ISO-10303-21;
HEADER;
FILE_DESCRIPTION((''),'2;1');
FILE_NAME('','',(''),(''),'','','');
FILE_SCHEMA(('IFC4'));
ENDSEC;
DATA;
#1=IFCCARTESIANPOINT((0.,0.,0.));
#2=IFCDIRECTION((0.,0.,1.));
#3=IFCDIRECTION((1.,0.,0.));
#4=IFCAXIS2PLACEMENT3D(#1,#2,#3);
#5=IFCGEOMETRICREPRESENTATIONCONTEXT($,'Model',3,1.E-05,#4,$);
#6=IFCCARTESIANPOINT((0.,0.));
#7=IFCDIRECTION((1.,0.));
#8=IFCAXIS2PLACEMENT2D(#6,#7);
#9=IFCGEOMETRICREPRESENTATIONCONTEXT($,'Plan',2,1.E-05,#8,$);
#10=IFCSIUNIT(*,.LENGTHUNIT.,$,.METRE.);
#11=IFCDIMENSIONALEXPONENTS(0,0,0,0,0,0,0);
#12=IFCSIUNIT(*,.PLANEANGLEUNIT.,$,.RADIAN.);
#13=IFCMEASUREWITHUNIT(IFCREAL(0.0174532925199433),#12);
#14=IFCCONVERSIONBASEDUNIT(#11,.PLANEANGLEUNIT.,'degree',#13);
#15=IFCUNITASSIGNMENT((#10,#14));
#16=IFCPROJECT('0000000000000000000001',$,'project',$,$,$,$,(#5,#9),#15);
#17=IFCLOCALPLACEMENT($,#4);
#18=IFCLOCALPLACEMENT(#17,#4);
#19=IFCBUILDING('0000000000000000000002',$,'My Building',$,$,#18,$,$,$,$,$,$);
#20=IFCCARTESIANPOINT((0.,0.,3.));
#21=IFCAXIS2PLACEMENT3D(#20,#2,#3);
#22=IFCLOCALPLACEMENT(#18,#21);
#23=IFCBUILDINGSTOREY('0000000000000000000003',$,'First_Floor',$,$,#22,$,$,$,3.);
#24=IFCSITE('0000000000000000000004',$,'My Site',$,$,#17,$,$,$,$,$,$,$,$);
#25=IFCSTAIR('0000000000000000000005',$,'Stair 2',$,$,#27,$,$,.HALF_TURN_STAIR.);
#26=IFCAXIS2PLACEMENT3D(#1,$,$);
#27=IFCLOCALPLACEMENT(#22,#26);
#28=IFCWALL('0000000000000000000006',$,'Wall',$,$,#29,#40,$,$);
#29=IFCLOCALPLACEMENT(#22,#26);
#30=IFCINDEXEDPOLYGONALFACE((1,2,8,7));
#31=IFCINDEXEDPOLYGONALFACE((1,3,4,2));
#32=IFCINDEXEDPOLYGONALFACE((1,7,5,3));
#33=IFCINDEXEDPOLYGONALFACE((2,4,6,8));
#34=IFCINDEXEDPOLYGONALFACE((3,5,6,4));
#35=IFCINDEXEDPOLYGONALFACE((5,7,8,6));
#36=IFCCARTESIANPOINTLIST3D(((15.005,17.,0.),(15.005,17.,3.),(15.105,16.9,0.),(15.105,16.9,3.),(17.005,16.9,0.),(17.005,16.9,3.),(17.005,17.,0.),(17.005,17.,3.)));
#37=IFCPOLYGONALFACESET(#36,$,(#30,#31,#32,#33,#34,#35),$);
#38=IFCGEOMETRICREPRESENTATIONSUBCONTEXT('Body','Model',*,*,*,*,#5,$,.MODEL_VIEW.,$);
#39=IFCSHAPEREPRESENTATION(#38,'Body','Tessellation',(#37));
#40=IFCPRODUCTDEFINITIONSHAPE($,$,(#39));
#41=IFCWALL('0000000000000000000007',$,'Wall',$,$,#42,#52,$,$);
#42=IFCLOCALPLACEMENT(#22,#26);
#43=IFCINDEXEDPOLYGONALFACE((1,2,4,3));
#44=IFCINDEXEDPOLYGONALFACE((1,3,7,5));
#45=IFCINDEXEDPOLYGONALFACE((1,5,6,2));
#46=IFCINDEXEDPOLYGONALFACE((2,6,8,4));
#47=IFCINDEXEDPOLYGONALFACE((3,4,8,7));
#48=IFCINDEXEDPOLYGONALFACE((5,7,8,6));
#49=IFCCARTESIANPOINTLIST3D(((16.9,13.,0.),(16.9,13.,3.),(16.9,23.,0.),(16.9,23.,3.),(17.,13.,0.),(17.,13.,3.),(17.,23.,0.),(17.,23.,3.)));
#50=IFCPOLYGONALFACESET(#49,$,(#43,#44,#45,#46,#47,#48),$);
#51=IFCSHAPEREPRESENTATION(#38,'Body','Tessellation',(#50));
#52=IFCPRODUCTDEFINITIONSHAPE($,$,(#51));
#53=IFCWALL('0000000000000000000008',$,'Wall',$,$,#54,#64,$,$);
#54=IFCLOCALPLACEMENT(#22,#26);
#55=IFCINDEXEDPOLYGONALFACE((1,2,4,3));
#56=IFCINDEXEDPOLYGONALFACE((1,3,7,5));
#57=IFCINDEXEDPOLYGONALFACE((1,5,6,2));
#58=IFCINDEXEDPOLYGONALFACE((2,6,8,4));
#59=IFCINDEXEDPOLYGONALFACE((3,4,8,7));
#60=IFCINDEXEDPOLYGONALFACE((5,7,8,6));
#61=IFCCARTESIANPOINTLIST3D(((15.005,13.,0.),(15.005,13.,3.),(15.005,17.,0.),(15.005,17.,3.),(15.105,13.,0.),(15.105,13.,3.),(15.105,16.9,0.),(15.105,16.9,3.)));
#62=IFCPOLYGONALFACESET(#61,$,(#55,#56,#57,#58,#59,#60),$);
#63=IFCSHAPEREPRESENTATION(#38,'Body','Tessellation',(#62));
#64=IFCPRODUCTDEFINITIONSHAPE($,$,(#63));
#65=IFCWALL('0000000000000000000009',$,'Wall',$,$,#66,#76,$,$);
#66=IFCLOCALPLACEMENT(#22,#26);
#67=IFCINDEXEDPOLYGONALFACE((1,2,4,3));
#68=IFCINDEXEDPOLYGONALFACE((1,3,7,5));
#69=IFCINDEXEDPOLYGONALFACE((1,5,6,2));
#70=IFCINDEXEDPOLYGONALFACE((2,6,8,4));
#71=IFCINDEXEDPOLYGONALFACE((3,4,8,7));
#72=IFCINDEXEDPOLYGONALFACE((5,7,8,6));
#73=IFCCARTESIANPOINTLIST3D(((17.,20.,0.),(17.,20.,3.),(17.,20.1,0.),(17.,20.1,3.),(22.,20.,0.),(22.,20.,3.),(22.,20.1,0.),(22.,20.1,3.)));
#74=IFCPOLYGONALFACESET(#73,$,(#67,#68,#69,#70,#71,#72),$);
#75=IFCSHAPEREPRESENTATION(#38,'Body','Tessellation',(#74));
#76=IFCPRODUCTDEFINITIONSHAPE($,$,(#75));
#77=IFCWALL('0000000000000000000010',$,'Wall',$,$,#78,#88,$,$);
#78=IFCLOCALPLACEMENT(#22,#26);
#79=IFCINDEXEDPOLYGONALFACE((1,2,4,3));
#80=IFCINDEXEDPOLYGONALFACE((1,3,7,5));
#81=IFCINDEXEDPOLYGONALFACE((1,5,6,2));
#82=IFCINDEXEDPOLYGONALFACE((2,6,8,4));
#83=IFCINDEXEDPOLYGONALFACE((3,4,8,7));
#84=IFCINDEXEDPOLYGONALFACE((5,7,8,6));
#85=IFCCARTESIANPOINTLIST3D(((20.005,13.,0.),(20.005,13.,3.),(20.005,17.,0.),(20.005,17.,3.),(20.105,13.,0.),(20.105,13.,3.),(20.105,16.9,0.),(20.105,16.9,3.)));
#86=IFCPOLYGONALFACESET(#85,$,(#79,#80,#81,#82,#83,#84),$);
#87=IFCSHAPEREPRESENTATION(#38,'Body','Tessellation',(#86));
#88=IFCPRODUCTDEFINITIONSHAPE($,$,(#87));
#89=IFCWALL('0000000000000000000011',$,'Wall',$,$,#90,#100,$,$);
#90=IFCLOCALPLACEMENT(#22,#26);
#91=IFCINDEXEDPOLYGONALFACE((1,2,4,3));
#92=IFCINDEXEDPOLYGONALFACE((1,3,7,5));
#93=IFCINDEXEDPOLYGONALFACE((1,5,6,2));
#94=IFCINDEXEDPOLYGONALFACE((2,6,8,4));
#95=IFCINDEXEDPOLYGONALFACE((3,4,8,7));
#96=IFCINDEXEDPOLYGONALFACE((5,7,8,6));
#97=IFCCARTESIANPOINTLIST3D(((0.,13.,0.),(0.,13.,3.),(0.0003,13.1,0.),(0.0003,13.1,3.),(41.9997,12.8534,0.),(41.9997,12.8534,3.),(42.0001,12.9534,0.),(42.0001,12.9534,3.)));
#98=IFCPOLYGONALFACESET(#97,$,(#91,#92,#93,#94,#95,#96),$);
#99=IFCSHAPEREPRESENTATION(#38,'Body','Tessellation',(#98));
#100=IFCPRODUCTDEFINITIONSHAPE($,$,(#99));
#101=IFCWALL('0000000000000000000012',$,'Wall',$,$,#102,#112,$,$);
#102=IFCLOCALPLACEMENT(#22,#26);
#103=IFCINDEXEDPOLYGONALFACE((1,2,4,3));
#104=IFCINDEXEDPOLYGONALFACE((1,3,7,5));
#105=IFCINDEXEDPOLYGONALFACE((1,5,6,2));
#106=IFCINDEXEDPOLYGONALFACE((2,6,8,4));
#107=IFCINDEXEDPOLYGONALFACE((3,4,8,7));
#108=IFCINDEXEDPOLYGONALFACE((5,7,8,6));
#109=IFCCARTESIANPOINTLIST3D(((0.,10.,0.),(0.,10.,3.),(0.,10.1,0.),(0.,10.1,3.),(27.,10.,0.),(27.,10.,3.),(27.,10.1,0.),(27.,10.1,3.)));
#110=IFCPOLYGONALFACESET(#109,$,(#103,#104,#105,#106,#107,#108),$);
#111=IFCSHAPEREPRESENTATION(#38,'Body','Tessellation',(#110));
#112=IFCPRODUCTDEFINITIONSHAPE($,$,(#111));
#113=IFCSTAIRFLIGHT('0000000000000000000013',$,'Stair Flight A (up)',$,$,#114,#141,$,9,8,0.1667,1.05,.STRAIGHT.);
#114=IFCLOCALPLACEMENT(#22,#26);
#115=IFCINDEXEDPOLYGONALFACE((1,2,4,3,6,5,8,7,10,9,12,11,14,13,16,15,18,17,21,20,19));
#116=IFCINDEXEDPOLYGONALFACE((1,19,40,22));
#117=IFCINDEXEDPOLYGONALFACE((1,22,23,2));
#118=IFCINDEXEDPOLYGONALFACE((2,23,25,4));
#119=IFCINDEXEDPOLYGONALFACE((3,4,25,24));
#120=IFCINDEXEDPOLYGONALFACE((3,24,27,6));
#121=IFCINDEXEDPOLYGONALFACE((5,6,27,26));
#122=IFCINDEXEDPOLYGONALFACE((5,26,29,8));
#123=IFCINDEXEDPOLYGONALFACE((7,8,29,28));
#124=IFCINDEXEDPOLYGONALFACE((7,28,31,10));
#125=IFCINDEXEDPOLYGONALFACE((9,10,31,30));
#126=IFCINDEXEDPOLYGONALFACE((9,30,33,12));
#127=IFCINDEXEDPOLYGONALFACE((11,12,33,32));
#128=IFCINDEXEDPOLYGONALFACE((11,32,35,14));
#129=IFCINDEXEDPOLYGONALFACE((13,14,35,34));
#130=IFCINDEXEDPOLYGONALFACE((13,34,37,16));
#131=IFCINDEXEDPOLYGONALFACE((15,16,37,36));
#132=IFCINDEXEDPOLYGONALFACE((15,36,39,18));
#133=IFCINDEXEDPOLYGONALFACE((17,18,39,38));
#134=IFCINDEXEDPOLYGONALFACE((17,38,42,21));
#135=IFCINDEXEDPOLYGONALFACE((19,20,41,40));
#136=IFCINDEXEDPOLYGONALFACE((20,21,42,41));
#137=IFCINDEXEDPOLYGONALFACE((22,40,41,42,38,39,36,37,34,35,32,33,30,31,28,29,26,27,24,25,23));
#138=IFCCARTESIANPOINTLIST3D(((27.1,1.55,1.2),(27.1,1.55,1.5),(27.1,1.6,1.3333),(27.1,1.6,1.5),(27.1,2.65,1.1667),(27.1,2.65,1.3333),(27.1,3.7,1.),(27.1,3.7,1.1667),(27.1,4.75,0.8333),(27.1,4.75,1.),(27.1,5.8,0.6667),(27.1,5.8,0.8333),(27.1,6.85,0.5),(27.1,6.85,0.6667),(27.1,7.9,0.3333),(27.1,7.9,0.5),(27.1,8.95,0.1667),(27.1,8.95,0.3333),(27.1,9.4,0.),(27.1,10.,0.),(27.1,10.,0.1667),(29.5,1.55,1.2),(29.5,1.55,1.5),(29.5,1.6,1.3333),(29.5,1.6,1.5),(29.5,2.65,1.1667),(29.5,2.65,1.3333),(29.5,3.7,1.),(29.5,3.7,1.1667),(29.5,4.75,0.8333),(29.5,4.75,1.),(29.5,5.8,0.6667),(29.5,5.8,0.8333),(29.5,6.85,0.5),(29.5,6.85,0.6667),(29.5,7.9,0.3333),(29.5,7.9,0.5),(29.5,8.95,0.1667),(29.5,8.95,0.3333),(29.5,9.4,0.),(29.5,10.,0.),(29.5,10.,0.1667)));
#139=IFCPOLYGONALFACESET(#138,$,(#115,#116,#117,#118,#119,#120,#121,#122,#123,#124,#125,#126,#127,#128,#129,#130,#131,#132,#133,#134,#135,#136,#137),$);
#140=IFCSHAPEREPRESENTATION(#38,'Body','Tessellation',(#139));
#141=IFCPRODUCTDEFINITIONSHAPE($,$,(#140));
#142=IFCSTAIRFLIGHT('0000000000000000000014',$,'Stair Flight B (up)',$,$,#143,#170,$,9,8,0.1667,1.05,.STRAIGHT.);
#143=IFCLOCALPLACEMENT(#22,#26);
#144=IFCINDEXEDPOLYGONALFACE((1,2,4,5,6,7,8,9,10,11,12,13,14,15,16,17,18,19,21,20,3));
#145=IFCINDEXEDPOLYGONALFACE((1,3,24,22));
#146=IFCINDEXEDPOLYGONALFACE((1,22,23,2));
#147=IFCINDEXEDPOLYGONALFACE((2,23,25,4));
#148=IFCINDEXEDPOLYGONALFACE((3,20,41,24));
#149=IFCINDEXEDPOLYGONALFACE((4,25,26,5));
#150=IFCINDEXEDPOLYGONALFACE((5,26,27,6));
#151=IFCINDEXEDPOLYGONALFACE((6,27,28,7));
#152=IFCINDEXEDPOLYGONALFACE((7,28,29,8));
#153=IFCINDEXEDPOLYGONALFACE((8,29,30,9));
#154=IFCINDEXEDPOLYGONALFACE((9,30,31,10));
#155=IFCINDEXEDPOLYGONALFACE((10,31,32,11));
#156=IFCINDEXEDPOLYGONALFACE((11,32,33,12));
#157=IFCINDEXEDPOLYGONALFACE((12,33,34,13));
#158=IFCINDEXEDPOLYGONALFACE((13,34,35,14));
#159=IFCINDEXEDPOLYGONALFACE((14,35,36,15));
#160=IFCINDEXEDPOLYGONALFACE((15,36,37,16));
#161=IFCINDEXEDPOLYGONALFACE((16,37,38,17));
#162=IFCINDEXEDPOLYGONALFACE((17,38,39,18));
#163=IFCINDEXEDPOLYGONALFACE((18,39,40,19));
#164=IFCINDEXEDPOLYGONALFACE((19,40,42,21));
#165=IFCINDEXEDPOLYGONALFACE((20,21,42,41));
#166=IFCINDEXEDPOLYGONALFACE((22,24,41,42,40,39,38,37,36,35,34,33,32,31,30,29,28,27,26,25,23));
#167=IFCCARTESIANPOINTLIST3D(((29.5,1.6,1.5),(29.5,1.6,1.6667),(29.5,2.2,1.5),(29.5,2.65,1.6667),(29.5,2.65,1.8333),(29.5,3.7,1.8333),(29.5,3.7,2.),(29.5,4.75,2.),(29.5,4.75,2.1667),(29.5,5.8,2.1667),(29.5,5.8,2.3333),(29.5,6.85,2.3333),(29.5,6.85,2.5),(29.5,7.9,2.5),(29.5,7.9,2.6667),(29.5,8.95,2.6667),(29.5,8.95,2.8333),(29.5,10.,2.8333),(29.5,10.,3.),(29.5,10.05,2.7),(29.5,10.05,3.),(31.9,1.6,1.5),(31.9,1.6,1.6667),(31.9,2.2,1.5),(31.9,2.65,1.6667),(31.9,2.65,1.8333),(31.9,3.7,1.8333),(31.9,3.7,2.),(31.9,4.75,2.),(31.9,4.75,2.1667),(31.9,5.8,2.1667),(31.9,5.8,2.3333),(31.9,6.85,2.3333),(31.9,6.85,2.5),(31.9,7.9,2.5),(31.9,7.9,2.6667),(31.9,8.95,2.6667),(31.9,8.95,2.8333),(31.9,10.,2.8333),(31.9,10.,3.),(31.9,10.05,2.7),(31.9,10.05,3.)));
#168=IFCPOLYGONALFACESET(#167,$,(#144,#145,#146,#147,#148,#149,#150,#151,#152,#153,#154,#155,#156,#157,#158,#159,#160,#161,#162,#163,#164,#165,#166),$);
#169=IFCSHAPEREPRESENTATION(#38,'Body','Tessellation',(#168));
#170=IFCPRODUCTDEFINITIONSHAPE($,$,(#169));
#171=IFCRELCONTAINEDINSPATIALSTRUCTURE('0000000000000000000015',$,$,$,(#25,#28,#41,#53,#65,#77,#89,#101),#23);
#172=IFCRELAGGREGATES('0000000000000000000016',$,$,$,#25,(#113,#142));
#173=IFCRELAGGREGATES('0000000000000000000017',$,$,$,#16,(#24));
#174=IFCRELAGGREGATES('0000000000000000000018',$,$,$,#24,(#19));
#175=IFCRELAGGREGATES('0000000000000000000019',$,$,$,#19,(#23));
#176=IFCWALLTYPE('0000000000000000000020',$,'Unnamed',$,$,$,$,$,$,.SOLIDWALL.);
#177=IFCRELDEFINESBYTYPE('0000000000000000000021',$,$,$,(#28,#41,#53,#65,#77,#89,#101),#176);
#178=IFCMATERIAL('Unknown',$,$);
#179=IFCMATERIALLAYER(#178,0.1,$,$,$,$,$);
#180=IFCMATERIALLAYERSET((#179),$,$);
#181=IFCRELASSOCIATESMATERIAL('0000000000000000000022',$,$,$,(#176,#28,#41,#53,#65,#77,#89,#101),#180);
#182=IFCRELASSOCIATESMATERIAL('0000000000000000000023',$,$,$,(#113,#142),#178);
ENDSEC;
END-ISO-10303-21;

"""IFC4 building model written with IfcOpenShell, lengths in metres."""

from ifc_helpers import new_model, entity, si_unit, converted_unit, frame, origin_with_axes, origin_2d_with_axis, place, context, subcontext, project, spatial, polyline, line, indexed_curve, outline, extrude, material, layer, layer_set, layer_usage, type_object, element, aggregate, save


model = new_model("IFC4")

# Units and contexts
model_context = context("Model", 3, precision=1e-05, world=origin_with_axes())
plan_context = context("Plan", 2, precision=1e-05, world=origin_2d_with_axis())
body_context = subcontext(model_context, "Body", "Model", "MODEL_VIEW")
ifc_project = project(units=[si_unit("LENGTHUNIT", "METRE"), converted_unit("PLANEANGLEUNIT", "degree", entity("IfcReal", 0.0174532925199433), si_unit("PLANEANGLEUNIT", "RADIAN"), dimensions=[0, 0, 0, 0, 0, 0, 0])], contexts=[model_context, plan_context])

# Site, building, storey
site_placement = place(None, origin_with_axes())
site = spatial("IfcSite", under=ifc_project, at=site_placement, Name="My Site")
building_placement = place(site_placement, origin_with_axes())
building = spatial("IfcBuilding", under=site, at=building_placement, Name="My Building")
storey_placement = place(building_placement, frame((0.0, 0.0, 3.0), z_axis=(0.0, 0.0, 1.0), x_axis=(1.0, 0.0, 0.0)))
storey = spatial("IfcBuildingStorey", under=building, at=storey_placement, Name="First_Floor", Elevation=3.0)

# Stair
stair_placement = place(storey_placement, origin_with_axes())
stair = element("IfcStair", 1, at=stair_placement, inside=storey, Name="Stair 2", PredefinedType="HALF_TURN_STAIR")
ifc_material = material(Name="Unknown")

# Walls
ifc_layer = layer(ifc_material, 0.1)
ifc_layer_set = layer_set([ifc_layer])
wall_type = type_object("IfcWallType", Name="Unnamed", PredefinedType="SOLIDWALL", material=ifc_layer_set)
ifc_layer_usage_1 = layer_usage(ifc_layer_set, "AXIS2", "POSITIVE", 0.0)
wall_1_placement = place(storey_placement, frame((17.005, 17.0, 0.0), z_axis=(0.0, 0.0, 1.0), x_axis=(-1.0, 0.0, 0.0)))
element("IfcWall", 2, at=wall_1_placement, inside=storey, type_object=wall_type, material=ifc_layer_usage_1, Name="Wall", context=body_context, shape_type="SweptSolid", body=[
    extrude(outline(indexed_curve([(0.0, 0.0), (0.0, 0.1), (1.9, 0.1), (2.0, 0.0)], segments=[line(1, 2, 3, 4, 1)])), origin_with_axes(), (0.0, 0.0, 1.0), 3.0),
])
ifc_layer_usage_2 = layer_usage(ifc_layer_set, "AXIS2", "POSITIVE", 0.0)
wall_2_placement = place(storey_placement, frame((16.9, 23.0, 0.0), z_axis=(0.0, 0.0, 1.0), x_axis=(0.0, -1.0, 0.0)))
element("IfcWall", 3, at=wall_2_placement, inside=storey, type_object=wall_type, material=ifc_layer_usage_2, Name="Wall", context=body_context, shape_type="SweptSolid", body=[
    extrude(outline(indexed_curve([(0.0, 0.0), (0.0, 0.1), (10.0, 0.1), (10.0, 0.0)], segments=[line(1, 2, 3, 4, 1)])), origin_with_axes(), (0.0, 0.0, 1.0), 3.0),
])
ifc_layer_usage_3 = layer_usage(ifc_layer_set, "AXIS2", "POSITIVE", 0.0)
wall_3_placement = place(storey_placement, frame((15.005, 17.0, 0.0), z_axis=(0.0, 0.0, 1.0), x_axis=(0.0, -1.0, 0.0)))
element("IfcWall", 4, at=wall_3_placement, inside=storey, type_object=wall_type, material=ifc_layer_usage_3, Name="Wall", context=body_context, shape_type="SweptSolid", body=[
    extrude(outline(indexed_curve([(0.0, 0.0), (0.1, 0.1), (4.0, 0.1), (4.0, 0.0)], segments=[line(1, 2, 3, 4, 1)])), origin_with_axes(), (0.0, 0.0, 1.0), 3.0),
])
ifc_layer_usage_4 = layer_usage(ifc_layer_set, "AXIS2", "POSITIVE", 0.0)
wall_4_placement = place(storey_placement, frame((17.0, 20.0, 0.0), z_axis=(0.0, 0.0, 1.0), x_axis=(1.0, 0.0, 0.0)))
element("IfcWall", 5, at=wall_4_placement, inside=storey, type_object=wall_type, material=ifc_layer_usage_4, Name="Wall", context=body_context, shape_type="SweptSolid", body=[
    extrude(outline(indexed_curve([(0.0, 0.0), (0.0, 0.1), (5.0, 0.1), (5.0, 0.0)], segments=[line(1, 2, 3, 4, 1)])), origin_with_axes(), (0.0, 0.0, 1.0), 3.0),
])
ifc_layer_usage_5 = layer_usage(ifc_layer_set, "AXIS2", "POSITIVE", 0.0)
wall_5_placement = place(storey_placement, frame((20.005, 17.0, 0.0), z_axis=(0.0, 0.0, 1.0), x_axis=(0.0, -1.0, 0.0)))
element("IfcWall", 6, at=wall_5_placement, inside=storey, type_object=wall_type, material=ifc_layer_usage_5, Name="Wall", context=body_context, shape_type="SweptSolid", body=[
    extrude(outline(indexed_curve([(0.0, 0.0), (0.1, 0.1), (4.0, 0.1), (4.0, 0.0)], segments=[line(1, 2, 3, 4, 1)])), origin_with_axes(), (0.0, 0.0, 1.0), 3.0),
])
ifc_layer_usage_6 = layer_usage(ifc_layer_set, "AXIS2", "POSITIVE", 0.0)
wall_6_placement = place(storey_placement, frame((0.0, 13.0, 0.0), z_axis=(0.0, 0.0, 1.0), x_axis=(0.999994, -0.003491, 0.0)))
element("IfcWall", 7, at=wall_6_placement, inside=storey, type_object=wall_type, material=ifc_layer_usage_6, Name="Wall", context=body_context, shape_type="SweptSolid", body=[
    extrude(outline(indexed_curve([(0.0, 0.0), (0.0, 0.1), (42.0, 0.1), (42.0, 0.0)], segments=[line(1, 2, 3, 4, 1)])), origin_with_axes(), (0.0, 0.0, 1.0), 3.0),
])
ifc_layer_usage_7 = layer_usage(ifc_layer_set, "AXIS2", "POSITIVE", 0.0)
wall_7_placement = place(storey_placement, frame((0.0, 10.0, 0.0), z_axis=(0.0, 0.0, 1.0), x_axis=(1.0, 0.0, 0.0)))
element("IfcWall", 8, at=wall_7_placement, inside=storey, type_object=wall_type, material=ifc_layer_usage_7, Name="Wall", context=body_context, shape_type="SweptSolid", body=[
    extrude(outline(indexed_curve([(0.0, 0.0), (0.0, 0.1), (27.0, 0.1), (27.0, 0.0)], segments=[line(1, 2, 3, 4, 1)])), origin_with_axes(), (0.0, 0.0, 1.0), 3.0),
])

# Stair flights
stair_flight_1_placement = place(stair_placement, origin_with_axes())
stair_flight_1 = element("IfcStairFlight", 9, at=stair_flight_1_placement, material=ifc_material, Name="Stair Flight A (up)", NumberOfRisers=9, NumberOfTreads=8, PredefinedType="STRAIGHT", RiserHeight=0.1667, TreadLength=1.05, context=body_context, shape_type="SweptSolid", body=[
    extrude(outline(polyline([(10.0, 0.0), (10.0, 0.1667), (8.95, 0.1667), (8.95, 0.3333), (7.9, 0.3333), (7.9, 0.3333), (7.9, 0.5), (6.85, 0.5), (6.85, 0.5), (6.85, 0.6667), (5.8, 0.6667), (5.8, 0.8333), (4.75, 0.8333), (4.75, 1.0), (3.7, 1.0), (3.7, 1.0), (3.7, 1.1667), (2.65, 1.1667), (2.65, 1.3333), (1.6, 1.3333), (1.6, 1.3333), (1.6, 1.5), (1.55, 1.5), (1.55, 1.2), (9.4, 0.0), (10.0, 0.0)])), frame((27.1, 0.0, 0.0), z_axis=(1.0, 0.0, 0.0), x_axis=(0.0, 1.0, 0.0)), (0.0, 0.0, 1.0), 2.4),
])
stair_flight_2_placement = place(stair_placement, origin_with_axes())
stair_flight_2 = element("IfcStairFlight", 10, at=stair_flight_2_placement, material=ifc_material, Name="Stair Flight B (up)", NumberOfRisers=9, NumberOfTreads=8, PredefinedType="STRAIGHT", RiserHeight=0.1667, TreadLength=1.05, context=body_context, shape_type="SweptSolid", body=[
    extrude(outline(polyline([(1.6, 1.5), (1.6, 1.6667), (2.65, 1.6667), (2.65, 1.8333), (3.7, 1.8333), (3.7, 1.8333), (3.7, 2.0), (4.75, 2.0), (4.75, 2.1667), (5.8, 2.1667), (5.8, 2.3333), (6.85, 2.3333), (6.85, 2.5), (7.9, 2.5), (7.9, 2.5), (7.9, 2.6667), (8.95, 2.6667), (8.95, 2.6667), (8.95, 2.8333), (10.0, 2.8333), (10.0, 3.0), (10.05, 3.0), (10.05, 2.7), (2.2, 1.5), (1.6, 1.5)])), frame((29.5, 0.0, 0.0), z_axis=(1.0, 0.0, 0.0), x_axis=(0.0, 1.0, 0.0)), (0.0, 0.0, 1.0), 2.4),
])
aggregate(stair, [stair_flight_1, stair_flight_2])

save(model, "model.ifc")
